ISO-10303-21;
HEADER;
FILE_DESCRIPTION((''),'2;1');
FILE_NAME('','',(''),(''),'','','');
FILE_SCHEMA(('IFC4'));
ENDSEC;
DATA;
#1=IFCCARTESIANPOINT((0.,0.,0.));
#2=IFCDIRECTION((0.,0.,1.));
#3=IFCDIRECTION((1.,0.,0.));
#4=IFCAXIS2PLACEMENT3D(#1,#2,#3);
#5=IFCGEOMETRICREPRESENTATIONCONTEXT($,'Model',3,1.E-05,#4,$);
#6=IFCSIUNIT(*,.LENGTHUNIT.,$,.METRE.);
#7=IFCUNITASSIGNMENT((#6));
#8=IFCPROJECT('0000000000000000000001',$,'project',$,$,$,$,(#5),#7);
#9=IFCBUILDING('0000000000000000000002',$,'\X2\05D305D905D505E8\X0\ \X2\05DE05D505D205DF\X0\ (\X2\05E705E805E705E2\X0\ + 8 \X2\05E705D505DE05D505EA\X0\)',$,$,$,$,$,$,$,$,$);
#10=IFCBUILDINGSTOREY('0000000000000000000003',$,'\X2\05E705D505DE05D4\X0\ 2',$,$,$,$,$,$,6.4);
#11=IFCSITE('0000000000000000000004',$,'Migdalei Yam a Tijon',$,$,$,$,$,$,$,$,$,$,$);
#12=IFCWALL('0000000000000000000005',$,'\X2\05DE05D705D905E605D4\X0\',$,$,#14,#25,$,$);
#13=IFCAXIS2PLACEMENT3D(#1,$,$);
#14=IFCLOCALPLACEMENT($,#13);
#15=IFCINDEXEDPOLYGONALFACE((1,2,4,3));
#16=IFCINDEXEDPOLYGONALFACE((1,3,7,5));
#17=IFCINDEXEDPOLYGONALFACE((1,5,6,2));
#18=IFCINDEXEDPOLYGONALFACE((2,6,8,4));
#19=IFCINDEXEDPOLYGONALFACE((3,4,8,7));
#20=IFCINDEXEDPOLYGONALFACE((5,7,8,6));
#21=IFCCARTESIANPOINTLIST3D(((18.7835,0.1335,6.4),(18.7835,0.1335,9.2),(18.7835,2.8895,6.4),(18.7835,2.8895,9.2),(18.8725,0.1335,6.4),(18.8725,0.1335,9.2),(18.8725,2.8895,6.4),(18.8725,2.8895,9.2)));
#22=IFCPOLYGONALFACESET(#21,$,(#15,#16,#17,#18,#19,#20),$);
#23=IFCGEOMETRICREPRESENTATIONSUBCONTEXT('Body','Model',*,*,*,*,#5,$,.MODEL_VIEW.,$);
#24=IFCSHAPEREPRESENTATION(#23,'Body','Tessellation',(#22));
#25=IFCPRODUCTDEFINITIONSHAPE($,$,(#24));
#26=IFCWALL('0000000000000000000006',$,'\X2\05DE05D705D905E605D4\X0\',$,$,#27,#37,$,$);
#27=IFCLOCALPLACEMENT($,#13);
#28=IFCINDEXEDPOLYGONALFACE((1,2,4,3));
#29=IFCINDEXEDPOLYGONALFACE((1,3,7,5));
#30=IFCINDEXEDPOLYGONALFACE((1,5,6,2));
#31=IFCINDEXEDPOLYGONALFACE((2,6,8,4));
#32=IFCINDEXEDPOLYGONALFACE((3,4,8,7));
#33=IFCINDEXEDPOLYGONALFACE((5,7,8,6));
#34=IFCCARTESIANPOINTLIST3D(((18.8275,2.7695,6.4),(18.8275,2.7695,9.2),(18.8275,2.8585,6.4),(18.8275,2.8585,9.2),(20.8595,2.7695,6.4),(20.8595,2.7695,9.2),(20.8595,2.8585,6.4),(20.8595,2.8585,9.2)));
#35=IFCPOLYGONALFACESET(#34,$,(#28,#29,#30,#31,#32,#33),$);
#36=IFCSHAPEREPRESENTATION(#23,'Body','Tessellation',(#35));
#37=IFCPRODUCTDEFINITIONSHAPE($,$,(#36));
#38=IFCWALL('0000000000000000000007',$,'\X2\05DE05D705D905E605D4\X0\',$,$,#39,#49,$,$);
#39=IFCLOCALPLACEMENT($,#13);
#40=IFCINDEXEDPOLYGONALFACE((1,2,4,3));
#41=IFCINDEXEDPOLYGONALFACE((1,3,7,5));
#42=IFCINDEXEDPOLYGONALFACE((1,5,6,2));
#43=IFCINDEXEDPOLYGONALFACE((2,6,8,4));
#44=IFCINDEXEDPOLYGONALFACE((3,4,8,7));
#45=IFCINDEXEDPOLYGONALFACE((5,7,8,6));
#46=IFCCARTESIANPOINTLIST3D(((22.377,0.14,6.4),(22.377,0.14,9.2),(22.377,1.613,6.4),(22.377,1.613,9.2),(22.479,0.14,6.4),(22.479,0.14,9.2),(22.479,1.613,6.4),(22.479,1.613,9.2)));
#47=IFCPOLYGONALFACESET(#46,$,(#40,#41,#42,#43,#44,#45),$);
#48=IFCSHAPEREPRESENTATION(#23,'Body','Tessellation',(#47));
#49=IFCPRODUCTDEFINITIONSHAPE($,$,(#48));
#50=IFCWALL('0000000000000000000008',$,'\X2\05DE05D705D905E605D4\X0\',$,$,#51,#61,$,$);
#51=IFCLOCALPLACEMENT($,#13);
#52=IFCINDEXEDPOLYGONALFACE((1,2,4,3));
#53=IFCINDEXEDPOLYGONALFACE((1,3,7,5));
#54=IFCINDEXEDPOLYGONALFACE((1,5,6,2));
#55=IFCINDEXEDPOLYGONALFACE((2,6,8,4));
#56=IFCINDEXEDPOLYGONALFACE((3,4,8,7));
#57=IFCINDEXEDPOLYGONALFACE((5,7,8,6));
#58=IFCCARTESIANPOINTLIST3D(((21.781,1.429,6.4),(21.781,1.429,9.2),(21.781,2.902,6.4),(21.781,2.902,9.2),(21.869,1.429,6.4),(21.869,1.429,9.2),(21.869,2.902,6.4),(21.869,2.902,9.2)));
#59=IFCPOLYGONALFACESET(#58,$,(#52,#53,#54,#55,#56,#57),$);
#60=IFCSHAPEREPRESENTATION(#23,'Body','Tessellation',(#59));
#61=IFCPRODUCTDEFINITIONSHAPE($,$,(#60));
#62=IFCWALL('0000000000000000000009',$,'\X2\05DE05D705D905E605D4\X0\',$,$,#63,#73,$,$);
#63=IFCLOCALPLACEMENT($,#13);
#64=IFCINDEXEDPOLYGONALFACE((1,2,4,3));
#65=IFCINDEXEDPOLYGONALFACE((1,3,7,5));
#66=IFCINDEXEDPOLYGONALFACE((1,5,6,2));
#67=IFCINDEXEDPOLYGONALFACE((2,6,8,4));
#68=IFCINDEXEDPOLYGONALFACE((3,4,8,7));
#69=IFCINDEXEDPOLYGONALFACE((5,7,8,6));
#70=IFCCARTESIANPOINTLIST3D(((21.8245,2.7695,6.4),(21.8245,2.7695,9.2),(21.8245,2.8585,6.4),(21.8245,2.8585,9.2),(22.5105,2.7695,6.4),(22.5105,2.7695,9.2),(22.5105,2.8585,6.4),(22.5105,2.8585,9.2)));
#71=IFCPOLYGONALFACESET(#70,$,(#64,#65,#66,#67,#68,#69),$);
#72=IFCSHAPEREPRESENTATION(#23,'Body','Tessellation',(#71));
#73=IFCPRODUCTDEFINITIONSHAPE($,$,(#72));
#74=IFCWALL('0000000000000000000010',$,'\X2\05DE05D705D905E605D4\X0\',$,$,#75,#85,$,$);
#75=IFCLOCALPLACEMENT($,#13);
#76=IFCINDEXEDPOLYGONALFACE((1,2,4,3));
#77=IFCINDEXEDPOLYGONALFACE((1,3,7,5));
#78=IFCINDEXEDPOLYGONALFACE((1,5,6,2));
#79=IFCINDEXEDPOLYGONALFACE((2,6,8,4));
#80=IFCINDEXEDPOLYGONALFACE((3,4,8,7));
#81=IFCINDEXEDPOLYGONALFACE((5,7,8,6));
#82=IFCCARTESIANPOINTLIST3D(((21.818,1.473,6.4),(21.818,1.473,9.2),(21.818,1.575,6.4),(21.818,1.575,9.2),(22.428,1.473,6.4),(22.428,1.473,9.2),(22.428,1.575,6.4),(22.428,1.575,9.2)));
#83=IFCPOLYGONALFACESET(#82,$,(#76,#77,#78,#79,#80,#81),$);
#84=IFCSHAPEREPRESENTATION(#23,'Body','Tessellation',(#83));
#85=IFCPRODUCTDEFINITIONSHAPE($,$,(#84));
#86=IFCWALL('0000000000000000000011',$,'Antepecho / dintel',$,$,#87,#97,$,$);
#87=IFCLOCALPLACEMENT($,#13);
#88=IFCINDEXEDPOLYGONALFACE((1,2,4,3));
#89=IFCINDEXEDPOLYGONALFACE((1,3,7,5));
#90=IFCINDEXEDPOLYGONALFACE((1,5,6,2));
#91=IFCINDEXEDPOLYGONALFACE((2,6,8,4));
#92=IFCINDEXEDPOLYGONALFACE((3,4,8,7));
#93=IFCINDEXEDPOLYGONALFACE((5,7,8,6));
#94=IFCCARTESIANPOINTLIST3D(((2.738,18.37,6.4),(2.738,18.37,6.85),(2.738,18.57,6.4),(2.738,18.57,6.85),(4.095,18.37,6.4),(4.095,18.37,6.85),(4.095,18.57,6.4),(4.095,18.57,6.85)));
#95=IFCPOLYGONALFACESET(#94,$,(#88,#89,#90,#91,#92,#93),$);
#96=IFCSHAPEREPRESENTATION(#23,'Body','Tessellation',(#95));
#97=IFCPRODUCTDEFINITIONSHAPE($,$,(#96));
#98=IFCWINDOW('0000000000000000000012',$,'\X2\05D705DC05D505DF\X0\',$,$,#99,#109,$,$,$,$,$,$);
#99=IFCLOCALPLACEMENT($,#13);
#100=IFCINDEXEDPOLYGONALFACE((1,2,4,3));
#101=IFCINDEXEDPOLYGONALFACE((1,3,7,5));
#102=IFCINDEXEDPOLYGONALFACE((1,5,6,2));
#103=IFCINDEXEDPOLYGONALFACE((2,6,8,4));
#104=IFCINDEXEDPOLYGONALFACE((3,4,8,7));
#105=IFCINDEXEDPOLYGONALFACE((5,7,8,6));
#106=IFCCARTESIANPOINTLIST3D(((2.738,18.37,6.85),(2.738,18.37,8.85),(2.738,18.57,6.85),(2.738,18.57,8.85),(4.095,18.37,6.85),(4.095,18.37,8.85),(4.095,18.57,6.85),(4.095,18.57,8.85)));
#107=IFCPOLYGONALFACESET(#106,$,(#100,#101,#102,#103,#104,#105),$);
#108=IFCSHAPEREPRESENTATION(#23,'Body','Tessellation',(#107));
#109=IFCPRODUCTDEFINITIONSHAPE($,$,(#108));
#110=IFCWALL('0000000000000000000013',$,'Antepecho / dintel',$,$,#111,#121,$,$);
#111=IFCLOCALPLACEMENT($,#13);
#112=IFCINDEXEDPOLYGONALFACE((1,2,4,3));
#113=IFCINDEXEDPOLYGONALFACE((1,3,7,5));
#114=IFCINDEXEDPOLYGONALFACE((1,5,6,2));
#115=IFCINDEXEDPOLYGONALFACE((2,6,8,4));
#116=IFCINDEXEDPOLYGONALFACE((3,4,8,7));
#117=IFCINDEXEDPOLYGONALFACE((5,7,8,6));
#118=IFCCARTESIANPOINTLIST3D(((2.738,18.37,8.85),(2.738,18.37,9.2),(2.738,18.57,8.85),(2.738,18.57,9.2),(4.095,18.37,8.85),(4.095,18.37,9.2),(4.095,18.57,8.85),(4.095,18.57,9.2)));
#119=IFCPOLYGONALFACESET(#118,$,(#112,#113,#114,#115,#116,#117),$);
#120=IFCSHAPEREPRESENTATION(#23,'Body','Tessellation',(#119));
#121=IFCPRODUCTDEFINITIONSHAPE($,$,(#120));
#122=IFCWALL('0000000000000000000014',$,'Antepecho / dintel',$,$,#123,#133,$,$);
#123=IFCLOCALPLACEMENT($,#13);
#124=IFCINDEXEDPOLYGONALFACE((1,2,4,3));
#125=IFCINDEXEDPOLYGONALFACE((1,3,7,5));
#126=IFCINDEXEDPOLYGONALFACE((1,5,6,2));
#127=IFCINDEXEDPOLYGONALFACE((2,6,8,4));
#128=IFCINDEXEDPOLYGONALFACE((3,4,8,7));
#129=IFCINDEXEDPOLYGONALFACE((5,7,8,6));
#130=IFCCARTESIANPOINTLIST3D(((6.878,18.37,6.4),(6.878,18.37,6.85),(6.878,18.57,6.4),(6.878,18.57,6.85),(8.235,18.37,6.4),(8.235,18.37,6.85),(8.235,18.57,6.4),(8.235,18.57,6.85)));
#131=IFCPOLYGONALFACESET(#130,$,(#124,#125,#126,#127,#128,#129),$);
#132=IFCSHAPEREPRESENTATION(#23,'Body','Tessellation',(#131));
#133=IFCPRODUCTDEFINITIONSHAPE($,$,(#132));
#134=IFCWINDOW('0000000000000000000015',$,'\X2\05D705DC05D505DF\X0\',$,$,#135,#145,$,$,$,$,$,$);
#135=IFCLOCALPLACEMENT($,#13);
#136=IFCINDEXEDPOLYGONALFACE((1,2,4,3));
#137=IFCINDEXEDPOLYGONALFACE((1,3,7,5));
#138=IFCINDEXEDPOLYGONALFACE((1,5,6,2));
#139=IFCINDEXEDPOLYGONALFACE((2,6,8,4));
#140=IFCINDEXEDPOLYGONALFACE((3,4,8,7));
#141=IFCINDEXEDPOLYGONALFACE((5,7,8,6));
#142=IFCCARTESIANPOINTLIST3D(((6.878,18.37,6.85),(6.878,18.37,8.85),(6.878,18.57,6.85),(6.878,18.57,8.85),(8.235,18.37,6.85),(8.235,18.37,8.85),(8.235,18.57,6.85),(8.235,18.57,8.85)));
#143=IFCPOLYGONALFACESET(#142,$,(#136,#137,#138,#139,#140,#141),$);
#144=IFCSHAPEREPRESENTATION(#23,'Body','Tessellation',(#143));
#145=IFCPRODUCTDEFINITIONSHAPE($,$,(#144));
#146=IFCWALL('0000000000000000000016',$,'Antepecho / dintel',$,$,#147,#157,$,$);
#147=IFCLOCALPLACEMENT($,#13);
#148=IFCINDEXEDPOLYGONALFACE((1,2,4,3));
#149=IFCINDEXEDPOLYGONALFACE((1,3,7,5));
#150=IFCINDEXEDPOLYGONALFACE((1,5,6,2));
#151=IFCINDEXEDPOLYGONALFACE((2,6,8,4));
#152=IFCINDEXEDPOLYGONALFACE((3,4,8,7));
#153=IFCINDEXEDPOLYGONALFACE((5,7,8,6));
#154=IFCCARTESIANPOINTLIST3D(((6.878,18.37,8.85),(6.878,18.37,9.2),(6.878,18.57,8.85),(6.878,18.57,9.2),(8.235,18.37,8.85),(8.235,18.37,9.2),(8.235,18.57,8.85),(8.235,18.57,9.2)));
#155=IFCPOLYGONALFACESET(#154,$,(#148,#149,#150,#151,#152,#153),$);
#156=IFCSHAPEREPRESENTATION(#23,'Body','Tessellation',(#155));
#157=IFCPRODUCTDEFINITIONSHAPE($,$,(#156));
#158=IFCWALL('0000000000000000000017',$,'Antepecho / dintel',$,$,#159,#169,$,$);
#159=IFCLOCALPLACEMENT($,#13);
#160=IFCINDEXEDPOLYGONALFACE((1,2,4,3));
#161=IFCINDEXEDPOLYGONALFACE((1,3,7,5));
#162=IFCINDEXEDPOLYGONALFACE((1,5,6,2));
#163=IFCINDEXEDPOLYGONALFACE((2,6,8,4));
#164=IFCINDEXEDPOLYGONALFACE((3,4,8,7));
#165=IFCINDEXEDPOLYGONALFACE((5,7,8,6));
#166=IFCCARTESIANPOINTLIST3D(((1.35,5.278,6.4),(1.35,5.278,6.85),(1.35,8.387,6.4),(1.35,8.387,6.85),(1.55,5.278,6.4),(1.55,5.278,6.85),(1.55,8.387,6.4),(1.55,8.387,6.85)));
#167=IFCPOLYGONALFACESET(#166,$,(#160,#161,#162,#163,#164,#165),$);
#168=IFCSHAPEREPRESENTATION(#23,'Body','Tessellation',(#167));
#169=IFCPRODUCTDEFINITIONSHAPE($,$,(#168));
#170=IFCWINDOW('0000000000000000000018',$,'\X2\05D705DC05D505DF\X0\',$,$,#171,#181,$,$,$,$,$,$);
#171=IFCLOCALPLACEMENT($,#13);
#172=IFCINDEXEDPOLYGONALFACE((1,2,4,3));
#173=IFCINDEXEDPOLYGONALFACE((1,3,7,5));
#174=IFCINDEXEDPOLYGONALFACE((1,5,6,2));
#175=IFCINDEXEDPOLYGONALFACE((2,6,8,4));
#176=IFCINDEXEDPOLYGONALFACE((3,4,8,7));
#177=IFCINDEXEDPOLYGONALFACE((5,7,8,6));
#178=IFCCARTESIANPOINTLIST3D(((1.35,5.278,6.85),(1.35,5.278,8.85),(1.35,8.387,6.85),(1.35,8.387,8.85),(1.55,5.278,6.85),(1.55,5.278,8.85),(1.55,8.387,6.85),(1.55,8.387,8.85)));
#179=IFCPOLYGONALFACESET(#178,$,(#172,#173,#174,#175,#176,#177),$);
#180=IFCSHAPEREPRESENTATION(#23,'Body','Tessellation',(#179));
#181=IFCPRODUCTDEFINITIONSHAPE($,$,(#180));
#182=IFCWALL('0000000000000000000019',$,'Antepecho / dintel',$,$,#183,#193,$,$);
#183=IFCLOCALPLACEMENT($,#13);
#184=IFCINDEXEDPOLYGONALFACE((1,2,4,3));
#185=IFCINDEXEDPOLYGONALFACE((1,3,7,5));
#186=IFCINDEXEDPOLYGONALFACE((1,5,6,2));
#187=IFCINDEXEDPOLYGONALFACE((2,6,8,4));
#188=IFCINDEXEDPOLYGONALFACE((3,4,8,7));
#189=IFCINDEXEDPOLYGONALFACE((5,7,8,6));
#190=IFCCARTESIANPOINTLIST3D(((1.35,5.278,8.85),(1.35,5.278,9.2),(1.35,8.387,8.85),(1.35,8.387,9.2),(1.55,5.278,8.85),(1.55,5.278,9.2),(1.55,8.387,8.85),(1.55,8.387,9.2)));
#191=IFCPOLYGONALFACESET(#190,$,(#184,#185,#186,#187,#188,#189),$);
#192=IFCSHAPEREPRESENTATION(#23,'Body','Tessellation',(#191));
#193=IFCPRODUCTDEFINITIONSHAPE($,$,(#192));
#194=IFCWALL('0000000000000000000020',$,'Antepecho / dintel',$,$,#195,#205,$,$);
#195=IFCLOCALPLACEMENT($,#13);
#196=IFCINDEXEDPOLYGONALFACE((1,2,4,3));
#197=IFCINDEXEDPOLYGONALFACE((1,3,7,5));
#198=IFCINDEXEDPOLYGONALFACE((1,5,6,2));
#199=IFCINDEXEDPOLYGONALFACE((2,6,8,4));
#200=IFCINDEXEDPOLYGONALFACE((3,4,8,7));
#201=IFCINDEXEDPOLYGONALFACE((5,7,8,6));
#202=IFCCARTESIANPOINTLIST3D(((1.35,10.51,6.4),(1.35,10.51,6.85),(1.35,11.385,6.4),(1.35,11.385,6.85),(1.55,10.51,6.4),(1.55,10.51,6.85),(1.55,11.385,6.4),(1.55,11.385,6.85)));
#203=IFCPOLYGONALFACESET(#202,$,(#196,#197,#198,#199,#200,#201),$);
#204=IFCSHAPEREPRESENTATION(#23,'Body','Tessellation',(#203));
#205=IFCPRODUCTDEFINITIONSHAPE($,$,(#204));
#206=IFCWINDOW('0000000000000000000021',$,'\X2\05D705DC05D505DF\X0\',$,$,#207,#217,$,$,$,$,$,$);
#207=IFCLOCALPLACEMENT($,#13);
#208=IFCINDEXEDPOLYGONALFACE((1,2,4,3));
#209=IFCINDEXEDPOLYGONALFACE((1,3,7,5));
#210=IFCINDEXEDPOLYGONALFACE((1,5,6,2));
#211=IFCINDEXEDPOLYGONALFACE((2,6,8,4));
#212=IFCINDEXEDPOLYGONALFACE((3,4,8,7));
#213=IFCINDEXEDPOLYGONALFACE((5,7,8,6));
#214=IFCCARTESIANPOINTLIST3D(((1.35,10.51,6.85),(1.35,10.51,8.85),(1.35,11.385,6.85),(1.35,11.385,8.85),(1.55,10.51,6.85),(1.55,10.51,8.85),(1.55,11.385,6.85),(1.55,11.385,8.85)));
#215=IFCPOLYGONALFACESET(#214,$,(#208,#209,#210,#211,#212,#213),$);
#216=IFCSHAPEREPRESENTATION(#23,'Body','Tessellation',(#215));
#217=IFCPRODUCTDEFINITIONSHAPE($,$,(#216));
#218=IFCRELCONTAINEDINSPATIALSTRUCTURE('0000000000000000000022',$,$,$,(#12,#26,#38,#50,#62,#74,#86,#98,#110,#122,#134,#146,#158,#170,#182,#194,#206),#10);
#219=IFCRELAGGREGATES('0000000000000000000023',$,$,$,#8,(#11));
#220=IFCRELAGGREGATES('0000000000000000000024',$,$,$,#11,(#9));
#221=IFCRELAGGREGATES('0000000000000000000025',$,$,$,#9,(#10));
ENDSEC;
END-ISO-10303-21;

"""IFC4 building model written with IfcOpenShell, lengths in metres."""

from ifc_helpers import new_model, si_unit, frame, origin_with_axes, context, subcontext, project, spatial, line, indexed_curve, outline, extrude, element, save


model = new_model("IFC4")

# Units and contexts
model_context = context("Model", 3, precision=1e-05, world=origin_with_axes())
body_context = subcontext(model_context, "Body", "Model", "MODEL_VIEW")
ifc_project = project(units=[si_unit("LENGTHUNIT", "METRE")], contexts=[model_context])

# Site, building, storey
site = spatial("IfcSite", under=ifc_project, Name="Migdalei Yam a Tijon")
building = spatial("IfcBuilding", under=site, Name="דיור מוגן (קרקע + 8 קומות)")
storey = spatial("IfcBuildingStorey", under=building, Name="קומה 2", Elevation=6.4)

# Walls
element("IfcWall", 1, inside=storey, Name="מחיצה", context=body_context, shape_type="SweptSolid", body=[
    extrude(outline(indexed_curve([(0.0, 0.0), (0.089, 0.0), (0.089, 2.756), (0.0, 2.756)], segments=[line(1, 2, 3, 4, 1)])), frame((18.7835, 0.1335, 6.4), z_axis=(0.0, 0.0, 1.0), x_axis=(1.0, 0.0, 0.0)), (0.0, 0.0, 1.0), 2.8),
])
element("IfcWall", 2, inside=storey, Name="מחיצה", context=body_context, shape_type="SweptSolid", body=[
    extrude(outline(indexed_curve([(0.0, 0.0), (2.032, 0.0), (2.032, 0.089), (0.0, 0.089)], segments=[line(1, 2, 3, 4, 1)])), frame((18.8275, 2.7695, 6.4), z_axis=(0.0, 0.0, 1.0), x_axis=(1.0, 0.0, 0.0)), (0.0, 0.0, 1.0), 2.8),
])
element("IfcWall", 3, inside=storey, Name="מחיצה", context=body_context, shape_type="SweptSolid", body=[
    extrude(outline(indexed_curve([(0.0, 0.0), (0.102, 0.0), (0.102, 1.473), (0.0, 1.473)], segments=[line(1, 2, 3, 4, 1)])), frame((22.377, 0.14, 6.4), z_axis=(0.0, 0.0, 1.0), x_axis=(1.0, 0.0, 0.0)), (0.0, 0.0, 1.0), 2.8),
])
element("IfcWall", 4, inside=storey, Name="מחיצה", context=body_context, shape_type="SweptSolid", body=[
    extrude(outline(indexed_curve([(0.0, 0.0), (0.088, 0.0), (0.088, 1.473), (0.0, 1.473)], segments=[line(1, 2, 3, 4, 1)])), frame((21.781, 1.429, 6.4), z_axis=(0.0, 0.0, 1.0), x_axis=(1.0, 0.0, 0.0)), (0.0, 0.0, 1.0), 2.8),
])
element("IfcWall", 5, inside=storey, Name="מחיצה", context=body_context, shape_type="SweptSolid", body=[
    extrude(outline(indexed_curve([(0.0, 0.0), (0.686, 0.0), (0.686, 0.089), (0.0, 0.089)], segments=[line(1, 2, 3, 4, 1)])), frame((21.8245, 2.7695, 6.4), z_axis=(0.0, 0.0, 1.0), x_axis=(1.0, 0.0, 0.0)), (0.0, 0.0, 1.0), 2.8),
])
element("IfcWall", 6, inside=storey, Name="מחיצה", context=body_context, shape_type="SweptSolid", body=[
    extrude(outline(indexed_curve([(0.0, 0.0), (0.61, 0.0), (0.61, 0.102), (0.0, 0.102)], segments=[line(1, 2, 3, 4, 1)])), frame((21.818, 1.473, 6.4), z_axis=(0.0, 0.0, 1.0), x_axis=(1.0, 0.0, 0.0)), (0.0, 0.0, 1.0), 2.8),
])
element("IfcWall", 7, inside=storey, Name="Antepecho / dintel", context=body_context, shape_type="SweptSolid", body=[
    extrude(outline(indexed_curve([(0.0, 0.0), (1.357, 0.0), (1.357, 0.2), (0.0, 0.2)], segments=[line(1, 2, 3, 4, 1)])), frame((2.738, 18.37, 6.4), z_axis=(0.0, 0.0, 1.0), x_axis=(1.0, 0.0, 0.0)), (0.0, 0.0, 1.0), 0.45),
])

# Window
element("IfcWindow", 8, inside=storey, Name="חלון", context=body_context, shape_type="SweptSolid", body=[
    extrude(outline(indexed_curve([(0.0, 0.0), (1.357, 0.0), (1.357, 0.2), (0.0, 0.2)], segments=[line(1, 2, 3, 4, 1)])), frame((2.738, 18.37, 6.85), z_axis=(0.0, 0.0, 1.0), x_axis=(1.0, 0.0, 0.0)), (0.0, 0.0, 1.0), 2.0),
])

# Walls
element("IfcWall", 9, inside=storey, Name="Antepecho / dintel", context=body_context, shape_type="SweptSolid", body=[
    extrude(outline(indexed_curve([(0.0, 0.0), (1.357, 0.0), (1.357, 0.2), (0.0, 0.2)], segments=[line(1, 2, 3, 4, 1)])), frame((2.738, 18.37, 8.85), z_axis=(0.0, 0.0, 1.0), x_axis=(1.0, 0.0, 0.0)), (0.0, 0.0, 1.0), 0.35),
])
element("IfcWall", 10, inside=storey, Name="Antepecho / dintel", context=body_context, shape_type="SweptSolid", body=[
    extrude(outline(indexed_curve([(0.0, 0.0), (1.357, 0.0), (1.357, 0.2), (0.0, 0.2)], segments=[line(1, 2, 3, 4, 1)])), frame((6.878, 18.37, 6.4), z_axis=(0.0, 0.0, 1.0), x_axis=(1.0, 0.0, 0.0)), (0.0, 0.0, 1.0), 0.45),
])

# Window
element("IfcWindow", 11, inside=storey, Name="חלון", context=body_context, shape_type="SweptSolid", body=[
    extrude(outline(indexed_curve([(0.0, 0.0), (1.357, 0.0), (1.357, 0.2), (0.0, 0.2)], segments=[line(1, 2, 3, 4, 1)])), frame((6.878, 18.37, 6.85), z_axis=(0.0, 0.0, 1.0), x_axis=(1.0, 0.0, 0.0)), (0.0, 0.0, 1.0), 2.0),
])

# Walls
element("IfcWall", 12, inside=storey, Name="Antepecho / dintel", context=body_context, shape_type="SweptSolid", body=[
    extrude(outline(indexed_curve([(0.0, 0.0), (1.357, 0.0), (1.357, 0.2), (0.0, 0.2)], segments=[line(1, 2, 3, 4, 1)])), frame((6.878, 18.37, 8.85), z_axis=(0.0, 0.0, 1.0), x_axis=(1.0, 0.0, 0.0)), (0.0, 0.0, 1.0), 0.35),
])
element("IfcWall", 13, inside=storey, Name="Antepecho / dintel", context=body_context, shape_type="SweptSolid", body=[
    extrude(outline(indexed_curve([(0.0, 0.0), (0.2, 0.0), (0.2, 3.109), (0.0, 3.109)], segments=[line(1, 2, 3, 4, 1)])), frame((1.35, 5.278, 6.4), z_axis=(0.0, 0.0, 1.0), x_axis=(1.0, 0.0, 0.0)), (0.0, 0.0, 1.0), 0.45),
])

# Window
element("IfcWindow", 14, inside=storey, Name="חלון", context=body_context, shape_type="SweptSolid", body=[
    extrude(outline(indexed_curve([(0.0, 0.0), (0.2, 0.0), (0.2, 3.109), (0.0, 3.109)], segments=[line(1, 2, 3, 4, 1)])), frame((1.35, 5.278, 6.85), z_axis=(0.0, 0.0, 1.0), x_axis=(1.0, 0.0, 0.0)), (0.0, 0.0, 1.0), 2.0),
])

# Walls
element("IfcWall", 15, inside=storey, Name="Antepecho / dintel", context=body_context, shape_type="SweptSolid", body=[
    extrude(outline(indexed_curve([(0.0, 0.0), (0.2, 0.0), (0.2, 3.109), (0.0, 3.109)], segments=[line(1, 2, 3, 4, 1)])), frame((1.35, 5.278, 8.85), z_axis=(0.0, 0.0, 1.0), x_axis=(1.0, 0.0, 0.0)), (0.0, 0.0, 1.0), 0.35),
])
element("IfcWall", 16, inside=storey, Name="Antepecho / dintel", context=body_context, shape_type="SweptSolid", body=[
    extrude(outline(indexed_curve([(0.0, 0.0), (0.2, 0.0), (0.2, 0.875), (0.0, 0.875)], segments=[line(1, 2, 3, 4, 1)])), frame((1.35, 10.51, 6.4), z_axis=(0.0, 0.0, 1.0), x_axis=(1.0, 0.0, 0.0)), (0.0, 0.0, 1.0), 0.45),
])

# Window
element("IfcWindow", 17, inside=storey, Name="חלון", context=body_context, shape_type="SweptSolid", body=[
    extrude(outline(indexed_curve([(0.0, 0.0), (0.2, 0.0), (0.2, 0.875), (0.0, 0.875)], segments=[line(1, 2, 3, 4, 1)])), frame((1.35, 10.51, 6.85), z_axis=(0.0, 0.0, 1.0), x_axis=(1.0, 0.0, 0.0)), (0.0, 0.0, 1.0), 2.0),
])

save(model, "model.ifc")
